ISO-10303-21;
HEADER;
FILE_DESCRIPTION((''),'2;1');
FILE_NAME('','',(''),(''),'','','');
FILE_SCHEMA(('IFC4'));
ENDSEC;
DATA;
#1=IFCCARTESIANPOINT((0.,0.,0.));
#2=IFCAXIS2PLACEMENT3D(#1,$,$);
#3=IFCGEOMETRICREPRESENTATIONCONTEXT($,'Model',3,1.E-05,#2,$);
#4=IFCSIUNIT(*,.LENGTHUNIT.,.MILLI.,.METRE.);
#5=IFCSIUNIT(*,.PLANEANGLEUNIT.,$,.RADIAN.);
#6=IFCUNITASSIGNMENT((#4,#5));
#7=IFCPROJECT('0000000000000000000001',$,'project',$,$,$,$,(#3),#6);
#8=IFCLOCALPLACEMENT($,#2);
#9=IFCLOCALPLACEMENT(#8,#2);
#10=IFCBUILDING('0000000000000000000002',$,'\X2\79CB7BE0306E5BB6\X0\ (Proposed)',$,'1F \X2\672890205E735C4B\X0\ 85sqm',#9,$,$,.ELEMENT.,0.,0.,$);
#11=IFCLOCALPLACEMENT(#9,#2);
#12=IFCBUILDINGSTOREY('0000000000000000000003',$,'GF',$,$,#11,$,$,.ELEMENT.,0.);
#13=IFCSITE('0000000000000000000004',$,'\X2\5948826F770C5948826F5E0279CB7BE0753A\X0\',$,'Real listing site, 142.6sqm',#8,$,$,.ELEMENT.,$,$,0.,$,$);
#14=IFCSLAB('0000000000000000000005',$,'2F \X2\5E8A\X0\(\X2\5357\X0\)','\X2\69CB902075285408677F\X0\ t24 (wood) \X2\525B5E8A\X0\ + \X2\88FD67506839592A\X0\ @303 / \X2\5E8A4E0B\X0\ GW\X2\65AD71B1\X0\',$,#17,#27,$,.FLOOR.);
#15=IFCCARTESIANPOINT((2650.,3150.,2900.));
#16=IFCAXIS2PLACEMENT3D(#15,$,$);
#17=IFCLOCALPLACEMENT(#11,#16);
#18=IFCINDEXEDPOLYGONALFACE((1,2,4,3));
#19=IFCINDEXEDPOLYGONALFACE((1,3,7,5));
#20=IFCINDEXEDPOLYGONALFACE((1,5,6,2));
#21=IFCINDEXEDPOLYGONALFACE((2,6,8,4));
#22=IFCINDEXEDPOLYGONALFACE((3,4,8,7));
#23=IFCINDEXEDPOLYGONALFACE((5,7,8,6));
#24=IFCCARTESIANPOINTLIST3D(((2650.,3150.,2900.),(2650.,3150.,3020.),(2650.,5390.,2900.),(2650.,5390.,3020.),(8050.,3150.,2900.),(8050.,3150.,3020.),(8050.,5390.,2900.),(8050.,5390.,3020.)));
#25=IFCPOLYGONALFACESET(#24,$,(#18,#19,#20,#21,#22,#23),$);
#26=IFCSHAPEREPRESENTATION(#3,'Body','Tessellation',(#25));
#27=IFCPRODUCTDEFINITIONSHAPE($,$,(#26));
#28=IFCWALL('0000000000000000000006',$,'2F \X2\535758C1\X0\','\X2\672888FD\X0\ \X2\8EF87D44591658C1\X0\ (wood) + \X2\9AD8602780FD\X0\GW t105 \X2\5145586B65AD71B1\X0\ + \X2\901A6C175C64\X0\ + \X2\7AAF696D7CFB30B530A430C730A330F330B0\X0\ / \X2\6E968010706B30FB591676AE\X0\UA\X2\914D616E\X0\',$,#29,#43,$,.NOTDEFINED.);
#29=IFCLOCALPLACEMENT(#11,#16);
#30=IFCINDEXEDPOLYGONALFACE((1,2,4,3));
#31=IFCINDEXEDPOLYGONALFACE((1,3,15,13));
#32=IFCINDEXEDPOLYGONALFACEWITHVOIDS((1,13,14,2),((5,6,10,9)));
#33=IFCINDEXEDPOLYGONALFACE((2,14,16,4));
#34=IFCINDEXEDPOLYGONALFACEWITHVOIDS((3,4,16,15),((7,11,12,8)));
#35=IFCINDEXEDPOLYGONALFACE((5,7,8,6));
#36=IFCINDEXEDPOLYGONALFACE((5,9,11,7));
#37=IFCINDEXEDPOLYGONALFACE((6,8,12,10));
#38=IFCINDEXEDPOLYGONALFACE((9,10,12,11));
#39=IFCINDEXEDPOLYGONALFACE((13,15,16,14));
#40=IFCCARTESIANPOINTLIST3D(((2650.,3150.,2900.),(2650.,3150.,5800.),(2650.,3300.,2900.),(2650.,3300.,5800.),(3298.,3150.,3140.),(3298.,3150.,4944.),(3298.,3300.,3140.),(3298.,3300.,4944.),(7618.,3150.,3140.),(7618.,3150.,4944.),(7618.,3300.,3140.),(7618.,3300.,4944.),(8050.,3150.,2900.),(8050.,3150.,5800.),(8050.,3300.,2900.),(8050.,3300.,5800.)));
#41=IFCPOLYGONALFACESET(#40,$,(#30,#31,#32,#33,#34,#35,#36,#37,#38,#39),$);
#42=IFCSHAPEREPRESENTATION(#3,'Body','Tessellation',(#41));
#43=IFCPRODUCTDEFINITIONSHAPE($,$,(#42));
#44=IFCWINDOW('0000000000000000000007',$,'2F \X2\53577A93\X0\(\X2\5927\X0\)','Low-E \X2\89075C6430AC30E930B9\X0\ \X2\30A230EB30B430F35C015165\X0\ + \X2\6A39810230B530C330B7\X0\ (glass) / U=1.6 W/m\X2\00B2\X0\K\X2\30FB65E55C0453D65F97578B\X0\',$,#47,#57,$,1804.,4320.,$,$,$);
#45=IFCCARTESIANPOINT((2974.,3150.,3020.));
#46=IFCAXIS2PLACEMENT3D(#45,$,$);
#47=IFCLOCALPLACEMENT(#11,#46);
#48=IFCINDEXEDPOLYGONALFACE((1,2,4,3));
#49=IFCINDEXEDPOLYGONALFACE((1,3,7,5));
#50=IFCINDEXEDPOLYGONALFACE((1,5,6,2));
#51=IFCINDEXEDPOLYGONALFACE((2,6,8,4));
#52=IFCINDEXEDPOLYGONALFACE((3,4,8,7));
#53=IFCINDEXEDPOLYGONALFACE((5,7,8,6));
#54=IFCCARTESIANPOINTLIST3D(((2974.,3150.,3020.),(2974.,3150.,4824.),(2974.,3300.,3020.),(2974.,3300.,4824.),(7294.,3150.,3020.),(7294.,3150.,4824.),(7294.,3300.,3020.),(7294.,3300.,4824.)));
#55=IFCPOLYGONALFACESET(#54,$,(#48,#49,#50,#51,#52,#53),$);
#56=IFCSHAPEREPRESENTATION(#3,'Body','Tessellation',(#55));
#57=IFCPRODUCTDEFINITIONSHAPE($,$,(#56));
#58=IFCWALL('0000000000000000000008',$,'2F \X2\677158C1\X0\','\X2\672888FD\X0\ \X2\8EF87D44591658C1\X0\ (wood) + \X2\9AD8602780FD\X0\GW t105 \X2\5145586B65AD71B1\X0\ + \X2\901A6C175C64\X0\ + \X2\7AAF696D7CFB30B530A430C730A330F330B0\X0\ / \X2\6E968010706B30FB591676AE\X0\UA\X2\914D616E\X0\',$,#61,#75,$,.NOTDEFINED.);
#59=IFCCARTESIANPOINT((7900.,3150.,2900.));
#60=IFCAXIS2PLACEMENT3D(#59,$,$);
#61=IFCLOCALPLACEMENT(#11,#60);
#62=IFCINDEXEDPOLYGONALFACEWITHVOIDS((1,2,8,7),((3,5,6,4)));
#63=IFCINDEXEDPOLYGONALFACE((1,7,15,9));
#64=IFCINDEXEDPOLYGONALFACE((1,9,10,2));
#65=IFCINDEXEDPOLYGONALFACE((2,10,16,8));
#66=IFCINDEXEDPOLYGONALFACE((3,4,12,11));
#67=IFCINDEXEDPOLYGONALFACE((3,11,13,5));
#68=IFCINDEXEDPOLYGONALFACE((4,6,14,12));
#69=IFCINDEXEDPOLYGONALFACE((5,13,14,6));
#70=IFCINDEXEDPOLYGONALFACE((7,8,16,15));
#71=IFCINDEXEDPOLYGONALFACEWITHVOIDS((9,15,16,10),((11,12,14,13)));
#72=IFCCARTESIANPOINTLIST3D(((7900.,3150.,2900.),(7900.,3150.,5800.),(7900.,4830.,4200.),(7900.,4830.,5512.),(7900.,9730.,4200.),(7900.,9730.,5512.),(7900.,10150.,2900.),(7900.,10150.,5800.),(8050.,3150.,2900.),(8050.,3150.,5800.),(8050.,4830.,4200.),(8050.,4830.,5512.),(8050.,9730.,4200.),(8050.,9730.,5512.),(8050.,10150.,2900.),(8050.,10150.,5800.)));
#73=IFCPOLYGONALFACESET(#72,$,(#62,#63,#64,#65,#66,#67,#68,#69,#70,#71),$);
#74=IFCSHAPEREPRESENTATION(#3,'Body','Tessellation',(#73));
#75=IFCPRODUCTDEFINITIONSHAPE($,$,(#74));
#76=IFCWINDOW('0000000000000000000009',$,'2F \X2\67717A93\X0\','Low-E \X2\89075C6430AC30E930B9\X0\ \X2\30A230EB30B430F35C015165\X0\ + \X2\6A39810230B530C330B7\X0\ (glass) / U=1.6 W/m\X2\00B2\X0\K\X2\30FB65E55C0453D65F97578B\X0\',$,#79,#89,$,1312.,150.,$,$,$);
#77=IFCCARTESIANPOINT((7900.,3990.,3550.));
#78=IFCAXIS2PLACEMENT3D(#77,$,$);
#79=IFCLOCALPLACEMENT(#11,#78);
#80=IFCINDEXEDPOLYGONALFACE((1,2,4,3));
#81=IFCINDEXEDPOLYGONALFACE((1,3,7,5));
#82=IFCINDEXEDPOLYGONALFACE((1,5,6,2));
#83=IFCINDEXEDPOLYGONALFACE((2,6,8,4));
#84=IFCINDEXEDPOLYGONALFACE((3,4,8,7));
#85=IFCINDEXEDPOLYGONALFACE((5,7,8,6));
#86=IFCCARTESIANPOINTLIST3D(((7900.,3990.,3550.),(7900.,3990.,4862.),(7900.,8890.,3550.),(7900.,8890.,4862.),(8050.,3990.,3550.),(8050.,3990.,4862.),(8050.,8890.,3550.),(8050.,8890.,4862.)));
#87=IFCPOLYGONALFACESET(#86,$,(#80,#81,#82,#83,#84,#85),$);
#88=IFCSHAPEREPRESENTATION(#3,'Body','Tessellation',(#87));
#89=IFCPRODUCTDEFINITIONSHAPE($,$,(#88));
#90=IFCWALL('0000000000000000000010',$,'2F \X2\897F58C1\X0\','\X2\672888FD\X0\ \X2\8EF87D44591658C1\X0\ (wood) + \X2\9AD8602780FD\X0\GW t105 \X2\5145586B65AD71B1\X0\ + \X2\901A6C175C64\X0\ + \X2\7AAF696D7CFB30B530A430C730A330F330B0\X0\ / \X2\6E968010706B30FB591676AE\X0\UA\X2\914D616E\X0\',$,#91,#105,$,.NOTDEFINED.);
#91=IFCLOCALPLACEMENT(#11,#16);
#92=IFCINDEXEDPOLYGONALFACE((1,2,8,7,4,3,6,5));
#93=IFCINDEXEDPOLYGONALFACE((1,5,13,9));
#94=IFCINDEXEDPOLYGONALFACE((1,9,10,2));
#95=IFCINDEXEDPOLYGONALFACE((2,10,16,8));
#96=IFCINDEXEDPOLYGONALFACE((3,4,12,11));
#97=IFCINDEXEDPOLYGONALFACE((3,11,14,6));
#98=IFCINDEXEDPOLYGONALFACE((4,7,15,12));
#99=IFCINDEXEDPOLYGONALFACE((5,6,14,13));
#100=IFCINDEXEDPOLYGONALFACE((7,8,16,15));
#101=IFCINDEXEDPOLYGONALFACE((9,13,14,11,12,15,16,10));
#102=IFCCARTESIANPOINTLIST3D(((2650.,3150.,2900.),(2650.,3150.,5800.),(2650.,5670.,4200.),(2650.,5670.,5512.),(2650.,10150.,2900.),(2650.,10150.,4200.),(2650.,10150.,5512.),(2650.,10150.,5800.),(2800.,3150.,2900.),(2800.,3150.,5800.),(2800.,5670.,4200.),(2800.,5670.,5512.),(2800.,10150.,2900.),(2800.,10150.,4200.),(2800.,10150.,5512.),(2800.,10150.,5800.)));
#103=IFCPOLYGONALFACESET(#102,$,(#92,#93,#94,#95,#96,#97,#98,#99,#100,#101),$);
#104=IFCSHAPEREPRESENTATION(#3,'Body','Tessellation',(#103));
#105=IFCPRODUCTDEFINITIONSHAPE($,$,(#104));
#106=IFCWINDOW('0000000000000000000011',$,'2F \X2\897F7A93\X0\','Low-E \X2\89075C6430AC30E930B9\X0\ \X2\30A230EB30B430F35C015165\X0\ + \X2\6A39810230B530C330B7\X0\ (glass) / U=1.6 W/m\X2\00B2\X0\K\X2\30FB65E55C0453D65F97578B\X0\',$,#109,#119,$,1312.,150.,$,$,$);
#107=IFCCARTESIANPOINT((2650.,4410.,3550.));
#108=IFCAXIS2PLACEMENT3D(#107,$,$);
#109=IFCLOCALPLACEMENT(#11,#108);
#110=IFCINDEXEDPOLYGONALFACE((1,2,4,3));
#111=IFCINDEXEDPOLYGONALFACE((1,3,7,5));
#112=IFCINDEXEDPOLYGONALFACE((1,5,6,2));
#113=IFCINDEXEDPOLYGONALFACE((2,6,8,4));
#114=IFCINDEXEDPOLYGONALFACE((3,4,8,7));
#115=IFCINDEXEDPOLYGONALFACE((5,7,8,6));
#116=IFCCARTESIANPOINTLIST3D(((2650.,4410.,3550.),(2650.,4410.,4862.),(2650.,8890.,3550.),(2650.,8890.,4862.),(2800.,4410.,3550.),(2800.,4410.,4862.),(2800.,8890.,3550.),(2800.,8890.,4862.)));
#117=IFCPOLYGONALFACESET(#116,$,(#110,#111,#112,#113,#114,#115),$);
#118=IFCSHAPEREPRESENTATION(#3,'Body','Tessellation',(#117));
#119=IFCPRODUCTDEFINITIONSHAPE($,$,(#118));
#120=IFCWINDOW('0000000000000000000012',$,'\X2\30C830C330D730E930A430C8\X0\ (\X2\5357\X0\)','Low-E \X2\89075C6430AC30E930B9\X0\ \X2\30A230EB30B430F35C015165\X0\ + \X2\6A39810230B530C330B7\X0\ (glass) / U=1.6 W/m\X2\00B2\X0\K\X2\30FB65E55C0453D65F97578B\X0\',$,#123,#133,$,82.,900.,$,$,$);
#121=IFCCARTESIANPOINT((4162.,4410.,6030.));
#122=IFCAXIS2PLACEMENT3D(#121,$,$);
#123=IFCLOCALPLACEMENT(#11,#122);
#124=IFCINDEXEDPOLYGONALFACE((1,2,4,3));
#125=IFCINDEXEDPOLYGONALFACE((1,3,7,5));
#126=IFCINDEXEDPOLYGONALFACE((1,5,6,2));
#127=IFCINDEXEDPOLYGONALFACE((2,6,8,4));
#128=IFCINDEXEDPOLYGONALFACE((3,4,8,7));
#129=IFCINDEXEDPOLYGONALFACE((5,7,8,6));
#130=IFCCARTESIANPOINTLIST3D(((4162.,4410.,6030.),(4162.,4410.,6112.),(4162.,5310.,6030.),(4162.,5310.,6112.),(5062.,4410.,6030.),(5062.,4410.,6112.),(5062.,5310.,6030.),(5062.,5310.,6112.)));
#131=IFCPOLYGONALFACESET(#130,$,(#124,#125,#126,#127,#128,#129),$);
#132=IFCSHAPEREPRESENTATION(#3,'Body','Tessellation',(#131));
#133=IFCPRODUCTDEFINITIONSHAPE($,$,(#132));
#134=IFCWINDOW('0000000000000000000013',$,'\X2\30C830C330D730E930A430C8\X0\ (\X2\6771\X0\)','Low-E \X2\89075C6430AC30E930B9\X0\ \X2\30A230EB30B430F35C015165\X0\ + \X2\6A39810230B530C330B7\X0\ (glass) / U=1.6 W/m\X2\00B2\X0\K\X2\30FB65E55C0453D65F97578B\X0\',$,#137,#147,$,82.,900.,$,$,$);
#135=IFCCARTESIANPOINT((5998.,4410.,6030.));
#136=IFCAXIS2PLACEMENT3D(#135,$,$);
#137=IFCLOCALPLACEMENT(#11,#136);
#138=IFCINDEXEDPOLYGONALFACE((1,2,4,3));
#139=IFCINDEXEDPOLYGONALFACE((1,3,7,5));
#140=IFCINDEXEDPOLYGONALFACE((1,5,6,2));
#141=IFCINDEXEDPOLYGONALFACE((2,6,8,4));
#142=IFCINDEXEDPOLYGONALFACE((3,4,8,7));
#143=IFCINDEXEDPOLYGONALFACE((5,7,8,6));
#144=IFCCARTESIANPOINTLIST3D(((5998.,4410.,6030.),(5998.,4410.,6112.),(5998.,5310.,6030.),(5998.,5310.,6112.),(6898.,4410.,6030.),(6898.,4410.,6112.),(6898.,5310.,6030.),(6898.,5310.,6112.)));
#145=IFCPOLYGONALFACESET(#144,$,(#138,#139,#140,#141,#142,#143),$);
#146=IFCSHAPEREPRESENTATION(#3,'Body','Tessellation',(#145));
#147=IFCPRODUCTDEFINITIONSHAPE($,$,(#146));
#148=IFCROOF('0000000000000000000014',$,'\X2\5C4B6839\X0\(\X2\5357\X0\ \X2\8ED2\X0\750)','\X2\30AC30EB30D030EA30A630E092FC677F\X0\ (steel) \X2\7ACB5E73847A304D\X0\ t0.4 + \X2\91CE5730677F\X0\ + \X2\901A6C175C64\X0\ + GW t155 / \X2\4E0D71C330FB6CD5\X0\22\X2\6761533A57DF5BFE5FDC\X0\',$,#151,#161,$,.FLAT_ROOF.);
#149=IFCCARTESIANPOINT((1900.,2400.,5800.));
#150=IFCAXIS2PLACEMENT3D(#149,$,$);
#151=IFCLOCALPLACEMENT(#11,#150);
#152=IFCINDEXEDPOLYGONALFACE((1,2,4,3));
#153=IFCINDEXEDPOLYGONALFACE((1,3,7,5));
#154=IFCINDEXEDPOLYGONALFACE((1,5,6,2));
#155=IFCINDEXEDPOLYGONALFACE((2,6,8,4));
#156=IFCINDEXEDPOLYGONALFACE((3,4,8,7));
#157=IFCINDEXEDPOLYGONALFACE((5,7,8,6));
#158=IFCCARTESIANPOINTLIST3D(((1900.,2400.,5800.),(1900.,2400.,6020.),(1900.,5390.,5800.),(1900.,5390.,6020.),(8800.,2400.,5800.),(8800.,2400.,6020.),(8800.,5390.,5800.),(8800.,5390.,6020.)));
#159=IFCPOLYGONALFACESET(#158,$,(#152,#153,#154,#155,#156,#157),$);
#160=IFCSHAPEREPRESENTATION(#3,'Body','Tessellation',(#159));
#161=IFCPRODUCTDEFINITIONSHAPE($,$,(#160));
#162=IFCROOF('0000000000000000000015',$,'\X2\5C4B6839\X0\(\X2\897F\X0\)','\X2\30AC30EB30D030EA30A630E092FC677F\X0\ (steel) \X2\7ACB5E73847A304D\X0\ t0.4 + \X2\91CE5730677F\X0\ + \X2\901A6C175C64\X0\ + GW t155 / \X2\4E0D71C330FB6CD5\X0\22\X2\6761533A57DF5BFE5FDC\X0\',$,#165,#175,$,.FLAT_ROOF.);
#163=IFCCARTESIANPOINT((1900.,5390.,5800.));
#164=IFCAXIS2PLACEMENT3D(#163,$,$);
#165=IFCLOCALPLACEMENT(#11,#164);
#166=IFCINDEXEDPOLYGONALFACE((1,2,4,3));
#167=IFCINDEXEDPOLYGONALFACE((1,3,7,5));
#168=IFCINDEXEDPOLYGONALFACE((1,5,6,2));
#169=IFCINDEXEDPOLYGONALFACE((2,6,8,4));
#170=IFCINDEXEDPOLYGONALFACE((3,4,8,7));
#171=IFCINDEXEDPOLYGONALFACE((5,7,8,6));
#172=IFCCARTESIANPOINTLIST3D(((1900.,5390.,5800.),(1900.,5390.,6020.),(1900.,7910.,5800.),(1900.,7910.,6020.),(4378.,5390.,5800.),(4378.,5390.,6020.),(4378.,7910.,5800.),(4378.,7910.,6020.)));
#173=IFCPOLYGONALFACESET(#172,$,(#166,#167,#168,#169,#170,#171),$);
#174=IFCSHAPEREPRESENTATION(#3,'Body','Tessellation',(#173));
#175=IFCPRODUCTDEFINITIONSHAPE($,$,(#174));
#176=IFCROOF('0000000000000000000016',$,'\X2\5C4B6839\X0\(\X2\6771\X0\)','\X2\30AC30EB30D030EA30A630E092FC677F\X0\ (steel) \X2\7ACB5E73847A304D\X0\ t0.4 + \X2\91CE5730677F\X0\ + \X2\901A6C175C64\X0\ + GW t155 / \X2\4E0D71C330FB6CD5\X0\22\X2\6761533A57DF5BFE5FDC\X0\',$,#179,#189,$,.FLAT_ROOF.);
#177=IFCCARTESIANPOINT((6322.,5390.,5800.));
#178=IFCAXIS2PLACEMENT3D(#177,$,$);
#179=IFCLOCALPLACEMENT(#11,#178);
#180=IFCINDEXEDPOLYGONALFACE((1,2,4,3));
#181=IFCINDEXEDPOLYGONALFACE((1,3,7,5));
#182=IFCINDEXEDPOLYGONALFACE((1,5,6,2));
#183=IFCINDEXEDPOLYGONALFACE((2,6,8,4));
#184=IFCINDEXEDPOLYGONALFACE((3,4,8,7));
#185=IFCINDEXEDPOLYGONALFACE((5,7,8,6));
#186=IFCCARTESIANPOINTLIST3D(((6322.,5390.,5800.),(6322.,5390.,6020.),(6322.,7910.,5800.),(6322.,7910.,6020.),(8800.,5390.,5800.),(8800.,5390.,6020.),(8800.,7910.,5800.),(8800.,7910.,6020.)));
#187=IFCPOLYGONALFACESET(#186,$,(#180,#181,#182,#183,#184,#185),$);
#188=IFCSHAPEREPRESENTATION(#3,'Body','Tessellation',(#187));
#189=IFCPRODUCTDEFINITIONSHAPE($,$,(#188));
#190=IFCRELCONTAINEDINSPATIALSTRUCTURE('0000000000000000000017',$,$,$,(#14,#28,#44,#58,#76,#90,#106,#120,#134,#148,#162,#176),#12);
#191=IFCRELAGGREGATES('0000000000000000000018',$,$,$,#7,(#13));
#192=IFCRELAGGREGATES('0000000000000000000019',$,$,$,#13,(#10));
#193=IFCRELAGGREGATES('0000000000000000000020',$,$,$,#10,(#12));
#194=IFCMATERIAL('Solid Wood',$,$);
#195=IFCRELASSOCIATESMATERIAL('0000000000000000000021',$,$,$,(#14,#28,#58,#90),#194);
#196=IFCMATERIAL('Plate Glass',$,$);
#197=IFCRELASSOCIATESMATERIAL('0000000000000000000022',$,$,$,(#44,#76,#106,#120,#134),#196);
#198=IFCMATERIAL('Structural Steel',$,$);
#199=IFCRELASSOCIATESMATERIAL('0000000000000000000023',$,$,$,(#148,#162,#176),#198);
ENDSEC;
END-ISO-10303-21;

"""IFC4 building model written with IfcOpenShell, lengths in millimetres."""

from ifc_helpers import new_model, si_unit, frame, frame_2d, origin, place, context, project, spatial, rectangle, extrude, material, element, fill, save


model = new_model("IFC4")

# Units and contexts
model_context = context("Model", 3, precision=1e-05, world=origin())
ifc_project = project(units=[si_unit("LENGTHUNIT", "METRE", prefix="MILLI"), si_unit("PLANEANGLEUNIT", "RADIAN")], contexts=[model_context])

# Site, building, storey
site_placement = place(None, origin())
site = spatial("IfcSite", under=ifc_project, at=site_placement, Name="奈良県奈良市秋篠町", ObjectType="Real listing site, 142.6sqm", CompositionType="ELEMENT", RefElevation=0.0)
building_placement = place(site_placement, origin())
building = spatial("IfcBuilding", under=site, at=building_placement, Name="秋篠の家 (Proposed)", ObjectType="1F 木造平屋 85sqm", CompositionType="ELEMENT", ElevationOfRefHeight=0.0, ElevationOfTerrain=0.0)
storey_placement = place(building_placement, origin())
storey = spatial("IfcBuildingStorey", under=building, at=storey_placement, Name="GF", CompositionType="ELEMENT", Elevation=0.0)

# Slab
ifc_material_1 = material(Name="Solid Wood")
slab_placement = place(storey_placement, frame((2650.0, 3150.0, 2900.0)))
element("IfcSlab", 1, at=slab_placement, inside=storey, material=ifc_material_1, Name="2F 床(南)", Description="構造用合板 t24 (wood) 剛床 + 製材根太 @303 / 床下 GW断熱", PredefinedType="FLOOR", context=model_context, shape_type="SweptSolid", body=[
    extrude(rectangle(XDim=5400.0, YDim=2240.0, at=frame_2d((2700.0, 1120.0))), frame((2650.0, 3150.0, 2900.0)), (0.0, 0.0, 1.0), 120.0),
])

# Walls, openings, windows
wall_1_placement = place(storey_placement, frame((2650.0, 3150.0, 2900.0)))
wall_1 = element("IfcWall", 2, at=wall_1_placement, inside=storey, material=ifc_material_1, Name="2F 南壁", Description="木製 軸組外壁 (wood) + 高性能GW t105 充填断熱 + 通気層 + 窯業系サイディング / 準耐火・外皮UA配慮", PredefinedType="NOTDEFINED", context=model_context, shape_type="SweptSolid", body=[
    extrude(rectangle(XDim=5400.0, YDim=150.0, at=frame_2d((2700.0, 75.0))), frame((2650.0, 3150.0, 2900.0)), (0.0, 0.0, 1.0), 2900.0),
])
opening_1_placement = place(storey_placement, frame((2974.0, 3150.0, 3020.0)))
opening_1 = element("IfcOpeningElement", 3, at=opening_1_placement, cuts=wall_1, PredefinedType="NOTDEFINED", context=model_context, shape_type="SweptSolid", body=[
    extrude(rectangle(XDim=4320.0, YDim=150.0, at=frame_2d((2160.0, 75.0))), frame((2974.0, 3150.0, 3020.0)), (0.0, 0.0, 1.0), 1804.0),
])
ifc_material_2 = material(Name="Plate Glass")
window_1_placement = place(storey_placement, frame((2974.0, 3150.0, 3020.0)))
window_1 = element("IfcWindow", 4, at=window_1_placement, inside=storey, material=ifc_material_2, Name="2F 南窓(大)", Description="Low-E 複層ガラス アルゴン封入 + 樹脂サッシ (glass) / U=1.6 W/m²K・日射取得型", OverallHeight=1804.0, OverallWidth=4320.0, context=model_context, shape_type="SweptSolid", body=[
    extrude(rectangle(XDim=4320.0, YDim=150.0, at=frame_2d((2160.0, 75.0))), frame((2974.0, 3150.0, 3020.0)), (0.0, 0.0, 1.0), 1804.0),
])
fill(opening_1, window_1)
wall_2_placement = place(storey_placement, frame((7900.0, 3150.0, 2900.0)))
wall_2 = element("IfcWall", 5, at=wall_2_placement, inside=storey, material=ifc_material_1, Name="2F 東壁", Description="木製 軸組外壁 (wood) + 高性能GW t105 充填断熱 + 通気層 + 窯業系サイディング / 準耐火・外皮UA配慮", PredefinedType="NOTDEFINED", context=model_context, shape_type="SweptSolid", body=[
    extrude(rectangle(XDim=150.0, YDim=7000.0, at=frame_2d((75.0, 3500.0))), frame((7900.0, 3150.0, 2900.0)), (0.0, 0.0, 1.0), 2900.0),
])
opening_2_placement = place(storey_placement, frame((7900.0, 3990.0, 3550.0)))
opening_2 = element("IfcOpeningElement", 6, at=opening_2_placement, cuts=wall_2, PredefinedType="NOTDEFINED", context=model_context, shape_type="SweptSolid", body=[
    extrude(rectangle(XDim=150.0, YDim=4900.0, at=frame_2d((75.0, 2450.0))), frame((7900.0, 3990.0, 3550.0)), (0.0, 0.0, 1.0), 1312.0),
])
window_2_placement = place(storey_placement, frame((7900.0, 3990.0, 3550.0)))
window_2 = element("IfcWindow", 7, at=window_2_placement, inside=storey, material=ifc_material_2, Name="2F 東窓", Description="Low-E 複層ガラス アルゴン封入 + 樹脂サッシ (glass) / U=1.6 W/m²K・日射取得型", OverallHeight=1312.0, OverallWidth=150.0, context=model_context, shape_type="SweptSolid", body=[
    extrude(rectangle(XDim=150.0, YDim=4900.0, at=frame_2d((75.0, 2450.0))), frame((7900.0, 3990.0, 3550.0)), (0.0, 0.0, 1.0), 1312.0),
])
fill(opening_2, window_2)
wall_3_placement = place(storey_placement, frame((2650.0, 3150.0, 2900.0)))
wall_3 = element("IfcWall", 8, at=wall_3_placement, inside=storey, material=ifc_material_1, Name="2F 西壁", Description="木製 軸組外壁 (wood) + 高性能GW t105 充填断熱 + 通気層 + 窯業系サイディング / 準耐火・外皮UA配慮", PredefinedType="NOTDEFINED", context=model_context, shape_type="SweptSolid", body=[
    extrude(rectangle(XDim=150.0, YDim=7000.0, at=frame_2d((75.0, 3500.0))), frame((2650.0, 3150.0, 2900.0)), (0.0, 0.0, 1.0), 2900.0),
])
opening_3_placement = place(storey_placement, frame((2650.0, 4410.0, 3550.0)))
opening_3 = element("IfcOpeningElement", 9, at=opening_3_placement, cuts=wall_3, PredefinedType="NOTDEFINED", context=model_context, shape_type="SweptSolid", body=[
    extrude(rectangle(XDim=150.0, YDim=4480.0, at=frame_2d((75.0, 2240.0))), frame((2650.0, 4410.0, 3550.0)), (0.0, 0.0, 1.0), 1312.0),
])
window_3_placement = place(storey_placement, frame((2650.0, 4410.0, 3550.0)))
window_3 = element("IfcWindow", 10, at=window_3_placement, inside=storey, material=ifc_material_2, Name="2F 西窓", Description="Low-E 複層ガラス アルゴン封入 + 樹脂サッシ (glass) / U=1.6 W/m²K・日射取得型", OverallHeight=1312.0, OverallWidth=150.0, context=model_context, shape_type="SweptSolid", body=[
    extrude(rectangle(XDim=150.0, YDim=4480.0, at=frame_2d((75.0, 2240.0))), frame((2650.0, 4410.0, 3550.0)), (0.0, 0.0, 1.0), 1312.0),
])
fill(opening_3, window_3)

# Windows
window_4_placement = place(storey_placement, frame((4162.0, 4410.0, 6030.0)))
element("IfcWindow", 11, at=window_4_placement, inside=storey, material=ifc_material_2, Name="トップライト (南)", Description="Low-E 複層ガラス アルゴン封入 + 樹脂サッシ (glass) / U=1.6 W/m²K・日射取得型", OverallHeight=82.0, OverallWidth=900.0, context=model_context, shape_type="SweptSolid", body=[
    extrude(rectangle(XDim=900.0, YDim=900.0, at=frame_2d((450.0, 450.0))), frame((4162.0, 4410.0, 6030.0)), (0.0, 0.0, 1.0), 82.0),
])
window_5_placement = place(storey_placement, frame((5998.0, 4410.0, 6030.0)))
element("IfcWindow", 12, at=window_5_placement, inside=storey, material=ifc_material_2, Name="トップライト (東)", Description="Low-E 複層ガラス アルゴン封入 + 樹脂サッシ (glass) / U=1.6 W/m²K・日射取得型", OverallHeight=82.0, OverallWidth=900.0, context=model_context, shape_type="SweptSolid", body=[
    extrude(rectangle(XDim=900.0, YDim=900.0, at=frame_2d((450.0, 450.0))), frame((5998.0, 4410.0, 6030.0)), (0.0, 0.0, 1.0), 82.0),
])

# Roofs
ifc_material_3 = material(Name="Structural Steel")
roof_1_placement = place(storey_placement, frame((1900.0, 2400.0, 5800.0)))
element("IfcRoof", 13, at=roof_1_placement, inside=storey, material=ifc_material_3, Name="屋根(南 軒750)", Description="ガルバリウム鋼板 (steel) 立平葺き t0.4 + 野地板 + 通気層 + GW t155 / 不燃・法22条区域対応", PredefinedType="FLAT_ROOF", context=model_context, shape_type="SweptSolid", body=[
    extrude(rectangle(XDim=6900.0, YDim=2990.0, at=frame_2d((3450.0, 1495.0))), frame((1900.0, 2400.0, 5800.0)), (0.0, 0.0, 1.0), 220.0),
])
roof_2_placement = place(storey_placement, frame((1900.0, 5390.0, 5800.0)))
element("IfcRoof", 14, at=roof_2_placement, inside=storey, material=ifc_material_3, Name="屋根(西)", Description="ガルバリウム鋼板 (steel) 立平葺き t0.4 + 野地板 + 通気層 + GW t155 / 不燃・法22条区域対応", PredefinedType="FLAT_ROOF", context=model_context, shape_type="SweptSolid", body=[
    extrude(rectangle(XDim=2478.0, YDim=2520.0, at=frame_2d((1239.0, 1260.0))), frame((1900.0, 5390.0, 5800.0)), (0.0, 0.0, 1.0), 220.0),
])
roof_3_placement = place(storey_placement, frame((6322.0, 5390.0, 5800.0)))
element("IfcRoof", 15, at=roof_3_placement, inside=storey, material=ifc_material_3, Name="屋根(東)", Description="ガルバリウム鋼板 (steel) 立平葺き t0.4 + 野地板 + 通気層 + GW t155 / 不燃・法22条区域対応", PredefinedType="FLAT_ROOF", context=model_context, shape_type="SweptSolid", body=[
    extrude(rectangle(XDim=2478.0, YDim=2520.0, at=frame_2d((1239.0, 1260.0))), frame((6322.0, 5390.0, 5800.0)), (0.0, 0.0, 1.0), 220.0),
])

save(model, "model.ifc")
